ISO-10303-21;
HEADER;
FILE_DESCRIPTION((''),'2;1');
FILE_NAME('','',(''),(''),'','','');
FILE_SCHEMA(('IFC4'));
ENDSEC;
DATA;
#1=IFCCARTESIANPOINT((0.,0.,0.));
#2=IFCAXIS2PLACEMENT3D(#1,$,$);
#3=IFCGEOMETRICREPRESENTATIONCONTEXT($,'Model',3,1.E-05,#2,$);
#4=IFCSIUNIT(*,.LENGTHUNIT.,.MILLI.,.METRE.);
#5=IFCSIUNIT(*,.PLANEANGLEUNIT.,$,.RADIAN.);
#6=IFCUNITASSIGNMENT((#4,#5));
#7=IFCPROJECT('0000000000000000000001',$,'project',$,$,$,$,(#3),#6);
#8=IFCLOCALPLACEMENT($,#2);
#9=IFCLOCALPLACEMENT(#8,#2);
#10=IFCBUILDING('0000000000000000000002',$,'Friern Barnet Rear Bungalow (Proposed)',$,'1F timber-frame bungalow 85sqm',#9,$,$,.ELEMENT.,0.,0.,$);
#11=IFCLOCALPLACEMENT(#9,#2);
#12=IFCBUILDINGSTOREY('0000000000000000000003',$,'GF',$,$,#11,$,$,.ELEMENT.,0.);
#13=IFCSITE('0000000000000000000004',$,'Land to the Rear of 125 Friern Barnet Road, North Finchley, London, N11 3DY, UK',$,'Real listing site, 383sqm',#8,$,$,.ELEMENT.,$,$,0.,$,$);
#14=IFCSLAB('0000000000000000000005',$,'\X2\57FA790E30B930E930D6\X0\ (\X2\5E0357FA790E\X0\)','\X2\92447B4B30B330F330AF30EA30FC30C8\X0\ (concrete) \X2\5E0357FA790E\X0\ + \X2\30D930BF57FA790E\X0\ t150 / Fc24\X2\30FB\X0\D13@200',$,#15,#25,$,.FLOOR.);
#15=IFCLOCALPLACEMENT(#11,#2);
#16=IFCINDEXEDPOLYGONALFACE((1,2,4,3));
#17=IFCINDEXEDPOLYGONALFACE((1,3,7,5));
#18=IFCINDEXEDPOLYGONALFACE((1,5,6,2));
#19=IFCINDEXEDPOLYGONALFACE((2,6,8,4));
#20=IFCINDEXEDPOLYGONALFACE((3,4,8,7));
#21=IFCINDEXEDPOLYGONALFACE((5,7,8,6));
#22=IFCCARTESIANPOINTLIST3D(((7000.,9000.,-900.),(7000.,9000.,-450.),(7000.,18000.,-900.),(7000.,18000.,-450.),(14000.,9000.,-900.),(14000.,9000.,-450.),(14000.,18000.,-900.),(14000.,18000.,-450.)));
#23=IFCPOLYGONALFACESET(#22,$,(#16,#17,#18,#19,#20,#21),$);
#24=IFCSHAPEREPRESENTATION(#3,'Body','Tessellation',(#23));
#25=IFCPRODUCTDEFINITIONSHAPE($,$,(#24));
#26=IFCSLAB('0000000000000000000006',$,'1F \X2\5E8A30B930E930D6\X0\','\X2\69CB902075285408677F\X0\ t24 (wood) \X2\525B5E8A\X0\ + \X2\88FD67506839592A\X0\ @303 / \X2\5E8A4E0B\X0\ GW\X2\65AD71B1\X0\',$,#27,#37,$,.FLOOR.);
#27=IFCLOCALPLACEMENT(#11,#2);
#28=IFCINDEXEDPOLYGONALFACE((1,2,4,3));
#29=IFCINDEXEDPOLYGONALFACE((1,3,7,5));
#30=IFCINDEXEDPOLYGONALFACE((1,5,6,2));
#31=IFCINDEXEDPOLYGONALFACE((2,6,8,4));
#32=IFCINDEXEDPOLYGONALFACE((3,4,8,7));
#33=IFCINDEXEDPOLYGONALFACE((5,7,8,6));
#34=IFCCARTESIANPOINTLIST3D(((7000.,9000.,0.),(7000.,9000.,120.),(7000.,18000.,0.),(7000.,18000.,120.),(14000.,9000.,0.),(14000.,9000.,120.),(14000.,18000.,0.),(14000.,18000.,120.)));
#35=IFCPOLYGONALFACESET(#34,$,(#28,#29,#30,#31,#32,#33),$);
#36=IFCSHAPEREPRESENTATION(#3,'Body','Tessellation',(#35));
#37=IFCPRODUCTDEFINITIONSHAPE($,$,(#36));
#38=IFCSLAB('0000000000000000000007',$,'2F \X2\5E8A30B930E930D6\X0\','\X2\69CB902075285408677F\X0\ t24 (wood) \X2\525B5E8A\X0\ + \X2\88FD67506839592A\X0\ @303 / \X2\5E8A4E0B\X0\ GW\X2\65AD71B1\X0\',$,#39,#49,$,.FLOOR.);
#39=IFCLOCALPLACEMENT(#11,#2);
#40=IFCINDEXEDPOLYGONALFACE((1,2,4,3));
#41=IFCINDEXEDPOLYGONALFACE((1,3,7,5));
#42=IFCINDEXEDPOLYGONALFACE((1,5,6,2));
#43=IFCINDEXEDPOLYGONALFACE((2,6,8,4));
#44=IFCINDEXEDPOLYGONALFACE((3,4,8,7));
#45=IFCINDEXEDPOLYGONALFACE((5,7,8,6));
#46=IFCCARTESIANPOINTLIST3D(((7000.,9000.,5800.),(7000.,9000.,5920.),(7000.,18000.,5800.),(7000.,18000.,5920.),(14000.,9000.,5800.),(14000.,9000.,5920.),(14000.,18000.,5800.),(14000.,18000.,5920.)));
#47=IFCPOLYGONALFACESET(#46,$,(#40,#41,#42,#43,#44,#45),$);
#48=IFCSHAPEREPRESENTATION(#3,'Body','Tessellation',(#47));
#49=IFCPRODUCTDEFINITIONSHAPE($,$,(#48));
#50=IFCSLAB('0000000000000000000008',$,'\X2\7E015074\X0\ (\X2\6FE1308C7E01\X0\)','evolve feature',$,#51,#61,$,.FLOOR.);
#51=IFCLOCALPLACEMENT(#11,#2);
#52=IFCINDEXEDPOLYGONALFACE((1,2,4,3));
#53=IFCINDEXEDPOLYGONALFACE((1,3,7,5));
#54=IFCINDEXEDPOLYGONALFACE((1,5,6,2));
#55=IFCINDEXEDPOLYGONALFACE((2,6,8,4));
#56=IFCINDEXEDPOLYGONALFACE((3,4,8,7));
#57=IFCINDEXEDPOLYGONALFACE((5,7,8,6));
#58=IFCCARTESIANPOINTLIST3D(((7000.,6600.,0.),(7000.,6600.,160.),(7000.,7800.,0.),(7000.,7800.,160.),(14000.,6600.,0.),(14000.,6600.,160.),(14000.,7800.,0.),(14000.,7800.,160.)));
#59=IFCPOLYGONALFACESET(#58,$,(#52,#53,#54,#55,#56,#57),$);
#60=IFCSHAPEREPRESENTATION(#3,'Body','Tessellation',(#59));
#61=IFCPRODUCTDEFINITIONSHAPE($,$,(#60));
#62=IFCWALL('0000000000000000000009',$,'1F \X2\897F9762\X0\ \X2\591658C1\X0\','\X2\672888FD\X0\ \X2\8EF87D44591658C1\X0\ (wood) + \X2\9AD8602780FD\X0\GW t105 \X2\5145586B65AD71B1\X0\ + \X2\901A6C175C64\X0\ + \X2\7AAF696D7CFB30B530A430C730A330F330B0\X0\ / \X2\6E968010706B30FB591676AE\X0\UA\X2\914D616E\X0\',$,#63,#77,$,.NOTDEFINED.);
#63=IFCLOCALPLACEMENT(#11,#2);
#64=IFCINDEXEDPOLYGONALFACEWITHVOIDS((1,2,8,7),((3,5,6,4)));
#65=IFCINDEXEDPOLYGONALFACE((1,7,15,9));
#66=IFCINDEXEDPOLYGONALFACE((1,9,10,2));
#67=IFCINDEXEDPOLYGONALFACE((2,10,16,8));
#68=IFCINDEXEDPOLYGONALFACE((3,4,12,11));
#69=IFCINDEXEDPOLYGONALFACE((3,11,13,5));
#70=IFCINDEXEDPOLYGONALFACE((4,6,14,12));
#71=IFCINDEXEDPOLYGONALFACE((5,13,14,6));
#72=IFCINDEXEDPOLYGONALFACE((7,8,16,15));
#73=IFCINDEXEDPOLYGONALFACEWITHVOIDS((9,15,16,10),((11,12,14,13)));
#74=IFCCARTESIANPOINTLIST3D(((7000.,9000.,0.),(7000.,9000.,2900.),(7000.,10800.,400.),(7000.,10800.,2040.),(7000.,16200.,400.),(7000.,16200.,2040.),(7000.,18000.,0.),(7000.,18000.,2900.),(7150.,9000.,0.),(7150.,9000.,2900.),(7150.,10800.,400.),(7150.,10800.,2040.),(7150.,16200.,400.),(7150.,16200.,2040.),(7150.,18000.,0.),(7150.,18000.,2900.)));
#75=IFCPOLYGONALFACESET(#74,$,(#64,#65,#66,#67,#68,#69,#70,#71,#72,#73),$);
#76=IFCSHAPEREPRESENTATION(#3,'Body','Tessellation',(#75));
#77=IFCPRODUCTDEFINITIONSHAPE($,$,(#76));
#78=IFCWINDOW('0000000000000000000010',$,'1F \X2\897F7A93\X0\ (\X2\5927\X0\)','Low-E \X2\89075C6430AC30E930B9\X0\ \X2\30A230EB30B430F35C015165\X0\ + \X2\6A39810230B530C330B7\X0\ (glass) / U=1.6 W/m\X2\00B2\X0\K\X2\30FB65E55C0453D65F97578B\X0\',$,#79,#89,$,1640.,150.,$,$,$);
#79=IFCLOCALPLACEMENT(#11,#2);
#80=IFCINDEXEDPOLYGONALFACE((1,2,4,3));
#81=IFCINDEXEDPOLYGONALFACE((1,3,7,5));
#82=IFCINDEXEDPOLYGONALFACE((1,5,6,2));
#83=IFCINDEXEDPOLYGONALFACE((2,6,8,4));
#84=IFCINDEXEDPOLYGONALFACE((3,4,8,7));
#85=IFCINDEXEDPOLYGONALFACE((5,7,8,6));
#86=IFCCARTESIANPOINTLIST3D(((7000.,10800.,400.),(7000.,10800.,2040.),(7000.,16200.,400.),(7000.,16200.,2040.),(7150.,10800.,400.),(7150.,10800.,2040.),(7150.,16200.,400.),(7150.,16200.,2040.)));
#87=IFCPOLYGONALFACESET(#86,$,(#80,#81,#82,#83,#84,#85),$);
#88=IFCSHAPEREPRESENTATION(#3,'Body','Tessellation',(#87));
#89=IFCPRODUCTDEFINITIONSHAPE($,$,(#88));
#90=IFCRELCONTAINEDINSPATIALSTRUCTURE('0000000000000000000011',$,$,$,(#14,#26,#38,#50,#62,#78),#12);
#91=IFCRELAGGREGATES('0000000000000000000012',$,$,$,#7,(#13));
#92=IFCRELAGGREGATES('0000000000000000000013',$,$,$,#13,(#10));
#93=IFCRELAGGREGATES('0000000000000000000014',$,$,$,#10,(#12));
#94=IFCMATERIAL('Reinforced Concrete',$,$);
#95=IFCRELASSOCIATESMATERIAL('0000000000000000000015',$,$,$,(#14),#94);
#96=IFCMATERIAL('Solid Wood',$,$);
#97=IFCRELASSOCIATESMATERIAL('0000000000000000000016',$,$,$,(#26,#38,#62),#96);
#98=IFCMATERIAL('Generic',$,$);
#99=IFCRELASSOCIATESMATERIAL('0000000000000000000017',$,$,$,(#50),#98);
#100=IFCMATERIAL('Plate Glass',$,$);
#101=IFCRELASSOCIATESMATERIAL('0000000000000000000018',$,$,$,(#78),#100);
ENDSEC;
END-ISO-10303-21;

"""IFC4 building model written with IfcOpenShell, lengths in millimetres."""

from ifc_helpers import new_model, si_unit, frame, frame_2d, origin, place, context, project, spatial, rectangle, extrude, material, element, fill, save


model = new_model("IFC4")

# Units and contexts
model_context = context("Model", 3, precision=1e-05, world=origin())
ifc_project = project(units=[si_unit("LENGTHUNIT", "METRE", prefix="MILLI"), si_unit("PLANEANGLEUNIT", "RADIAN")], contexts=[model_context])

# Site, building, storey
site_placement = place(None, origin())
site = spatial("IfcSite", under=ifc_project, at=site_placement, Name="Land to the Rear of 125 Friern Barnet Road, North Finchley, London, N11 3DY, UK", ObjectType="Real listing site, 383sqm", CompositionType="ELEMENT", RefElevation=0.0)
building_placement = place(site_placement, origin())
building = spatial("IfcBuilding", under=site, at=building_placement, Name="Friern Barnet Rear Bungalow (Proposed)", ObjectType="1F timber-frame bungalow 85sqm", CompositionType="ELEMENT", ElevationOfRefHeight=0.0, ElevationOfTerrain=0.0)
storey_placement = place(building_placement, origin())
storey = spatial("IfcBuildingStorey", under=building, at=storey_placement, Name="GF", CompositionType="ELEMENT", Elevation=0.0)

# Slabs
ifc_material_1 = material(Name="Reinforced Concrete")
slab_1_placement = place(storey_placement, frame((3500.0, 4500.0, -450.0)))
element("IfcSlab", 1, at=slab_1_placement, inside=storey, material=ifc_material_1, Name="基礎スラブ (布基礎)", Description="鉄筋コンクリート (concrete) 布基礎 + ベタ基礎 t150 / Fc24・D13@200", PredefinedType="FLOOR", context=model_context, shape_type="SweptSolid", body=[
    extrude(rectangle(XDim=7000.0, YDim=9000.0, at=frame_2d((3500.0, 4500.0))), frame((3500.0, 4500.0, -450.0)), (0.0, 0.0, 1.0), 450.0),
])
ifc_material_2 = material(Name="Solid Wood")
slab_2_placement = place(storey_placement, frame((3500.0, 4500.0, 0.0)))
element("IfcSlab", 2, at=slab_2_placement, inside=storey, material=ifc_material_2, Name="1F 床スラブ", Description="構造用合板 t24 (wood) 剛床 + 製材根太 @303 / 床下 GW断熱", PredefinedType="FLOOR", context=model_context, shape_type="SweptSolid", body=[
    extrude(rectangle(XDim=7000.0, YDim=9000.0, at=frame_2d((3500.0, 4500.0))), frame((3500.0, 4500.0, 0.0)), (0.0, 0.0, 1.0), 120.0),
])
slab_3_placement = place(storey_placement, frame((3500.0, 4500.0, 2900.0)))
element("IfcSlab", 3, at=slab_3_placement, inside=storey, material=ifc_material_2, Name="2F 床スラブ", Description="構造用合板 t24 (wood) 剛床 + 製材根太 @303 / 床下 GW断熱", PredefinedType="FLOOR", context=model_context, shape_type="SweptSolid", body=[
    extrude(rectangle(XDim=7000.0, YDim=9000.0, at=frame_2d((3500.0, 4500.0))), frame((3500.0, 4500.0, 2900.0)), (0.0, 0.0, 1.0), 120.0),
])
ifc_material_3 = material(Name="Generic")
slab_4_placement = place(storey_placement, frame((3500.0, 3300.0, 0.0)))
element("IfcSlab", 4, at=slab_4_placement, inside=storey, material=ifc_material_3, Name="縁側 (濡れ縁)", Description="evolve feature", PredefinedType="FLOOR", context=model_context, shape_type="SweptSolid", body=[
    extrude(rectangle(XDim=7000.0, YDim=1200.0, at=frame_2d((3500.0, 600.0))), frame((3500.0, 3300.0, 0.0)), (0.0, 0.0, 1.0), 160.0),
])

# Shared definitions
ifc_material_4 = material(Name="Plate Glass")

# Wall, opening, window
wall_1_placement = place(storey_placement, frame((3500.0, 4500.0, 0.0)))
wall_1 = element("IfcWall", 5, at=wall_1_placement, inside=storey, material=ifc_material_2, Name="1F 西面 外壁", Description="木製 軸組外壁 (wood) + 高性能GW t105 充填断熱 + 通気層 + 窯業系サイディング / 準耐火・外皮UA配慮", PredefinedType="NOTDEFINED", context=model_context, shape_type="SweptSolid", body=[
    extrude(rectangle(XDim=150.0, YDim=9000.0, at=frame_2d((75.0, 4500.0))), frame((3500.0, 4500.0, 0.0)), (0.0, 0.0, 1.0), 2900.0),
])
opening_1_placement = place(storey_placement, frame((3500.0, 5400.0, 200.0)))
opening_1 = element("IfcOpeningElement", 6, at=opening_1_placement, cuts=wall_1, PredefinedType="NOTDEFINED", context=model_context, shape_type="SweptSolid", body=[
    extrude(rectangle(XDim=150.0, YDim=5400.0, at=frame_2d((75.0, 2700.0))), frame((3500.0, 5400.0, 200.0)), (0.0, 0.0, 1.0), 1640.0),
])
window_1_placement = place(storey_placement, frame((3500.0, 5400.0, 200.0)))
window_1 = element("IfcWindow", 7, at=window_1_placement, inside=storey, material=ifc_material_4, Name="1F 西窓 (大)", Description="Low-E 複層ガラス アルゴン封入 + 樹脂サッシ (glass) / U=1.6 W/m²K・日射取得型", OverallHeight=1640.0, OverallWidth=150.0, context=model_context, shape_type="SweptSolid", body=[
    extrude(rectangle(XDim=150.0, YDim=5400.0, at=frame_2d((75.0, 2700.0))), frame((3500.0, 5400.0, 200.0)), (0.0, 0.0, 1.0), 1640.0),
])
fill(opening_1, window_1)

save(model, "model.ifc")
